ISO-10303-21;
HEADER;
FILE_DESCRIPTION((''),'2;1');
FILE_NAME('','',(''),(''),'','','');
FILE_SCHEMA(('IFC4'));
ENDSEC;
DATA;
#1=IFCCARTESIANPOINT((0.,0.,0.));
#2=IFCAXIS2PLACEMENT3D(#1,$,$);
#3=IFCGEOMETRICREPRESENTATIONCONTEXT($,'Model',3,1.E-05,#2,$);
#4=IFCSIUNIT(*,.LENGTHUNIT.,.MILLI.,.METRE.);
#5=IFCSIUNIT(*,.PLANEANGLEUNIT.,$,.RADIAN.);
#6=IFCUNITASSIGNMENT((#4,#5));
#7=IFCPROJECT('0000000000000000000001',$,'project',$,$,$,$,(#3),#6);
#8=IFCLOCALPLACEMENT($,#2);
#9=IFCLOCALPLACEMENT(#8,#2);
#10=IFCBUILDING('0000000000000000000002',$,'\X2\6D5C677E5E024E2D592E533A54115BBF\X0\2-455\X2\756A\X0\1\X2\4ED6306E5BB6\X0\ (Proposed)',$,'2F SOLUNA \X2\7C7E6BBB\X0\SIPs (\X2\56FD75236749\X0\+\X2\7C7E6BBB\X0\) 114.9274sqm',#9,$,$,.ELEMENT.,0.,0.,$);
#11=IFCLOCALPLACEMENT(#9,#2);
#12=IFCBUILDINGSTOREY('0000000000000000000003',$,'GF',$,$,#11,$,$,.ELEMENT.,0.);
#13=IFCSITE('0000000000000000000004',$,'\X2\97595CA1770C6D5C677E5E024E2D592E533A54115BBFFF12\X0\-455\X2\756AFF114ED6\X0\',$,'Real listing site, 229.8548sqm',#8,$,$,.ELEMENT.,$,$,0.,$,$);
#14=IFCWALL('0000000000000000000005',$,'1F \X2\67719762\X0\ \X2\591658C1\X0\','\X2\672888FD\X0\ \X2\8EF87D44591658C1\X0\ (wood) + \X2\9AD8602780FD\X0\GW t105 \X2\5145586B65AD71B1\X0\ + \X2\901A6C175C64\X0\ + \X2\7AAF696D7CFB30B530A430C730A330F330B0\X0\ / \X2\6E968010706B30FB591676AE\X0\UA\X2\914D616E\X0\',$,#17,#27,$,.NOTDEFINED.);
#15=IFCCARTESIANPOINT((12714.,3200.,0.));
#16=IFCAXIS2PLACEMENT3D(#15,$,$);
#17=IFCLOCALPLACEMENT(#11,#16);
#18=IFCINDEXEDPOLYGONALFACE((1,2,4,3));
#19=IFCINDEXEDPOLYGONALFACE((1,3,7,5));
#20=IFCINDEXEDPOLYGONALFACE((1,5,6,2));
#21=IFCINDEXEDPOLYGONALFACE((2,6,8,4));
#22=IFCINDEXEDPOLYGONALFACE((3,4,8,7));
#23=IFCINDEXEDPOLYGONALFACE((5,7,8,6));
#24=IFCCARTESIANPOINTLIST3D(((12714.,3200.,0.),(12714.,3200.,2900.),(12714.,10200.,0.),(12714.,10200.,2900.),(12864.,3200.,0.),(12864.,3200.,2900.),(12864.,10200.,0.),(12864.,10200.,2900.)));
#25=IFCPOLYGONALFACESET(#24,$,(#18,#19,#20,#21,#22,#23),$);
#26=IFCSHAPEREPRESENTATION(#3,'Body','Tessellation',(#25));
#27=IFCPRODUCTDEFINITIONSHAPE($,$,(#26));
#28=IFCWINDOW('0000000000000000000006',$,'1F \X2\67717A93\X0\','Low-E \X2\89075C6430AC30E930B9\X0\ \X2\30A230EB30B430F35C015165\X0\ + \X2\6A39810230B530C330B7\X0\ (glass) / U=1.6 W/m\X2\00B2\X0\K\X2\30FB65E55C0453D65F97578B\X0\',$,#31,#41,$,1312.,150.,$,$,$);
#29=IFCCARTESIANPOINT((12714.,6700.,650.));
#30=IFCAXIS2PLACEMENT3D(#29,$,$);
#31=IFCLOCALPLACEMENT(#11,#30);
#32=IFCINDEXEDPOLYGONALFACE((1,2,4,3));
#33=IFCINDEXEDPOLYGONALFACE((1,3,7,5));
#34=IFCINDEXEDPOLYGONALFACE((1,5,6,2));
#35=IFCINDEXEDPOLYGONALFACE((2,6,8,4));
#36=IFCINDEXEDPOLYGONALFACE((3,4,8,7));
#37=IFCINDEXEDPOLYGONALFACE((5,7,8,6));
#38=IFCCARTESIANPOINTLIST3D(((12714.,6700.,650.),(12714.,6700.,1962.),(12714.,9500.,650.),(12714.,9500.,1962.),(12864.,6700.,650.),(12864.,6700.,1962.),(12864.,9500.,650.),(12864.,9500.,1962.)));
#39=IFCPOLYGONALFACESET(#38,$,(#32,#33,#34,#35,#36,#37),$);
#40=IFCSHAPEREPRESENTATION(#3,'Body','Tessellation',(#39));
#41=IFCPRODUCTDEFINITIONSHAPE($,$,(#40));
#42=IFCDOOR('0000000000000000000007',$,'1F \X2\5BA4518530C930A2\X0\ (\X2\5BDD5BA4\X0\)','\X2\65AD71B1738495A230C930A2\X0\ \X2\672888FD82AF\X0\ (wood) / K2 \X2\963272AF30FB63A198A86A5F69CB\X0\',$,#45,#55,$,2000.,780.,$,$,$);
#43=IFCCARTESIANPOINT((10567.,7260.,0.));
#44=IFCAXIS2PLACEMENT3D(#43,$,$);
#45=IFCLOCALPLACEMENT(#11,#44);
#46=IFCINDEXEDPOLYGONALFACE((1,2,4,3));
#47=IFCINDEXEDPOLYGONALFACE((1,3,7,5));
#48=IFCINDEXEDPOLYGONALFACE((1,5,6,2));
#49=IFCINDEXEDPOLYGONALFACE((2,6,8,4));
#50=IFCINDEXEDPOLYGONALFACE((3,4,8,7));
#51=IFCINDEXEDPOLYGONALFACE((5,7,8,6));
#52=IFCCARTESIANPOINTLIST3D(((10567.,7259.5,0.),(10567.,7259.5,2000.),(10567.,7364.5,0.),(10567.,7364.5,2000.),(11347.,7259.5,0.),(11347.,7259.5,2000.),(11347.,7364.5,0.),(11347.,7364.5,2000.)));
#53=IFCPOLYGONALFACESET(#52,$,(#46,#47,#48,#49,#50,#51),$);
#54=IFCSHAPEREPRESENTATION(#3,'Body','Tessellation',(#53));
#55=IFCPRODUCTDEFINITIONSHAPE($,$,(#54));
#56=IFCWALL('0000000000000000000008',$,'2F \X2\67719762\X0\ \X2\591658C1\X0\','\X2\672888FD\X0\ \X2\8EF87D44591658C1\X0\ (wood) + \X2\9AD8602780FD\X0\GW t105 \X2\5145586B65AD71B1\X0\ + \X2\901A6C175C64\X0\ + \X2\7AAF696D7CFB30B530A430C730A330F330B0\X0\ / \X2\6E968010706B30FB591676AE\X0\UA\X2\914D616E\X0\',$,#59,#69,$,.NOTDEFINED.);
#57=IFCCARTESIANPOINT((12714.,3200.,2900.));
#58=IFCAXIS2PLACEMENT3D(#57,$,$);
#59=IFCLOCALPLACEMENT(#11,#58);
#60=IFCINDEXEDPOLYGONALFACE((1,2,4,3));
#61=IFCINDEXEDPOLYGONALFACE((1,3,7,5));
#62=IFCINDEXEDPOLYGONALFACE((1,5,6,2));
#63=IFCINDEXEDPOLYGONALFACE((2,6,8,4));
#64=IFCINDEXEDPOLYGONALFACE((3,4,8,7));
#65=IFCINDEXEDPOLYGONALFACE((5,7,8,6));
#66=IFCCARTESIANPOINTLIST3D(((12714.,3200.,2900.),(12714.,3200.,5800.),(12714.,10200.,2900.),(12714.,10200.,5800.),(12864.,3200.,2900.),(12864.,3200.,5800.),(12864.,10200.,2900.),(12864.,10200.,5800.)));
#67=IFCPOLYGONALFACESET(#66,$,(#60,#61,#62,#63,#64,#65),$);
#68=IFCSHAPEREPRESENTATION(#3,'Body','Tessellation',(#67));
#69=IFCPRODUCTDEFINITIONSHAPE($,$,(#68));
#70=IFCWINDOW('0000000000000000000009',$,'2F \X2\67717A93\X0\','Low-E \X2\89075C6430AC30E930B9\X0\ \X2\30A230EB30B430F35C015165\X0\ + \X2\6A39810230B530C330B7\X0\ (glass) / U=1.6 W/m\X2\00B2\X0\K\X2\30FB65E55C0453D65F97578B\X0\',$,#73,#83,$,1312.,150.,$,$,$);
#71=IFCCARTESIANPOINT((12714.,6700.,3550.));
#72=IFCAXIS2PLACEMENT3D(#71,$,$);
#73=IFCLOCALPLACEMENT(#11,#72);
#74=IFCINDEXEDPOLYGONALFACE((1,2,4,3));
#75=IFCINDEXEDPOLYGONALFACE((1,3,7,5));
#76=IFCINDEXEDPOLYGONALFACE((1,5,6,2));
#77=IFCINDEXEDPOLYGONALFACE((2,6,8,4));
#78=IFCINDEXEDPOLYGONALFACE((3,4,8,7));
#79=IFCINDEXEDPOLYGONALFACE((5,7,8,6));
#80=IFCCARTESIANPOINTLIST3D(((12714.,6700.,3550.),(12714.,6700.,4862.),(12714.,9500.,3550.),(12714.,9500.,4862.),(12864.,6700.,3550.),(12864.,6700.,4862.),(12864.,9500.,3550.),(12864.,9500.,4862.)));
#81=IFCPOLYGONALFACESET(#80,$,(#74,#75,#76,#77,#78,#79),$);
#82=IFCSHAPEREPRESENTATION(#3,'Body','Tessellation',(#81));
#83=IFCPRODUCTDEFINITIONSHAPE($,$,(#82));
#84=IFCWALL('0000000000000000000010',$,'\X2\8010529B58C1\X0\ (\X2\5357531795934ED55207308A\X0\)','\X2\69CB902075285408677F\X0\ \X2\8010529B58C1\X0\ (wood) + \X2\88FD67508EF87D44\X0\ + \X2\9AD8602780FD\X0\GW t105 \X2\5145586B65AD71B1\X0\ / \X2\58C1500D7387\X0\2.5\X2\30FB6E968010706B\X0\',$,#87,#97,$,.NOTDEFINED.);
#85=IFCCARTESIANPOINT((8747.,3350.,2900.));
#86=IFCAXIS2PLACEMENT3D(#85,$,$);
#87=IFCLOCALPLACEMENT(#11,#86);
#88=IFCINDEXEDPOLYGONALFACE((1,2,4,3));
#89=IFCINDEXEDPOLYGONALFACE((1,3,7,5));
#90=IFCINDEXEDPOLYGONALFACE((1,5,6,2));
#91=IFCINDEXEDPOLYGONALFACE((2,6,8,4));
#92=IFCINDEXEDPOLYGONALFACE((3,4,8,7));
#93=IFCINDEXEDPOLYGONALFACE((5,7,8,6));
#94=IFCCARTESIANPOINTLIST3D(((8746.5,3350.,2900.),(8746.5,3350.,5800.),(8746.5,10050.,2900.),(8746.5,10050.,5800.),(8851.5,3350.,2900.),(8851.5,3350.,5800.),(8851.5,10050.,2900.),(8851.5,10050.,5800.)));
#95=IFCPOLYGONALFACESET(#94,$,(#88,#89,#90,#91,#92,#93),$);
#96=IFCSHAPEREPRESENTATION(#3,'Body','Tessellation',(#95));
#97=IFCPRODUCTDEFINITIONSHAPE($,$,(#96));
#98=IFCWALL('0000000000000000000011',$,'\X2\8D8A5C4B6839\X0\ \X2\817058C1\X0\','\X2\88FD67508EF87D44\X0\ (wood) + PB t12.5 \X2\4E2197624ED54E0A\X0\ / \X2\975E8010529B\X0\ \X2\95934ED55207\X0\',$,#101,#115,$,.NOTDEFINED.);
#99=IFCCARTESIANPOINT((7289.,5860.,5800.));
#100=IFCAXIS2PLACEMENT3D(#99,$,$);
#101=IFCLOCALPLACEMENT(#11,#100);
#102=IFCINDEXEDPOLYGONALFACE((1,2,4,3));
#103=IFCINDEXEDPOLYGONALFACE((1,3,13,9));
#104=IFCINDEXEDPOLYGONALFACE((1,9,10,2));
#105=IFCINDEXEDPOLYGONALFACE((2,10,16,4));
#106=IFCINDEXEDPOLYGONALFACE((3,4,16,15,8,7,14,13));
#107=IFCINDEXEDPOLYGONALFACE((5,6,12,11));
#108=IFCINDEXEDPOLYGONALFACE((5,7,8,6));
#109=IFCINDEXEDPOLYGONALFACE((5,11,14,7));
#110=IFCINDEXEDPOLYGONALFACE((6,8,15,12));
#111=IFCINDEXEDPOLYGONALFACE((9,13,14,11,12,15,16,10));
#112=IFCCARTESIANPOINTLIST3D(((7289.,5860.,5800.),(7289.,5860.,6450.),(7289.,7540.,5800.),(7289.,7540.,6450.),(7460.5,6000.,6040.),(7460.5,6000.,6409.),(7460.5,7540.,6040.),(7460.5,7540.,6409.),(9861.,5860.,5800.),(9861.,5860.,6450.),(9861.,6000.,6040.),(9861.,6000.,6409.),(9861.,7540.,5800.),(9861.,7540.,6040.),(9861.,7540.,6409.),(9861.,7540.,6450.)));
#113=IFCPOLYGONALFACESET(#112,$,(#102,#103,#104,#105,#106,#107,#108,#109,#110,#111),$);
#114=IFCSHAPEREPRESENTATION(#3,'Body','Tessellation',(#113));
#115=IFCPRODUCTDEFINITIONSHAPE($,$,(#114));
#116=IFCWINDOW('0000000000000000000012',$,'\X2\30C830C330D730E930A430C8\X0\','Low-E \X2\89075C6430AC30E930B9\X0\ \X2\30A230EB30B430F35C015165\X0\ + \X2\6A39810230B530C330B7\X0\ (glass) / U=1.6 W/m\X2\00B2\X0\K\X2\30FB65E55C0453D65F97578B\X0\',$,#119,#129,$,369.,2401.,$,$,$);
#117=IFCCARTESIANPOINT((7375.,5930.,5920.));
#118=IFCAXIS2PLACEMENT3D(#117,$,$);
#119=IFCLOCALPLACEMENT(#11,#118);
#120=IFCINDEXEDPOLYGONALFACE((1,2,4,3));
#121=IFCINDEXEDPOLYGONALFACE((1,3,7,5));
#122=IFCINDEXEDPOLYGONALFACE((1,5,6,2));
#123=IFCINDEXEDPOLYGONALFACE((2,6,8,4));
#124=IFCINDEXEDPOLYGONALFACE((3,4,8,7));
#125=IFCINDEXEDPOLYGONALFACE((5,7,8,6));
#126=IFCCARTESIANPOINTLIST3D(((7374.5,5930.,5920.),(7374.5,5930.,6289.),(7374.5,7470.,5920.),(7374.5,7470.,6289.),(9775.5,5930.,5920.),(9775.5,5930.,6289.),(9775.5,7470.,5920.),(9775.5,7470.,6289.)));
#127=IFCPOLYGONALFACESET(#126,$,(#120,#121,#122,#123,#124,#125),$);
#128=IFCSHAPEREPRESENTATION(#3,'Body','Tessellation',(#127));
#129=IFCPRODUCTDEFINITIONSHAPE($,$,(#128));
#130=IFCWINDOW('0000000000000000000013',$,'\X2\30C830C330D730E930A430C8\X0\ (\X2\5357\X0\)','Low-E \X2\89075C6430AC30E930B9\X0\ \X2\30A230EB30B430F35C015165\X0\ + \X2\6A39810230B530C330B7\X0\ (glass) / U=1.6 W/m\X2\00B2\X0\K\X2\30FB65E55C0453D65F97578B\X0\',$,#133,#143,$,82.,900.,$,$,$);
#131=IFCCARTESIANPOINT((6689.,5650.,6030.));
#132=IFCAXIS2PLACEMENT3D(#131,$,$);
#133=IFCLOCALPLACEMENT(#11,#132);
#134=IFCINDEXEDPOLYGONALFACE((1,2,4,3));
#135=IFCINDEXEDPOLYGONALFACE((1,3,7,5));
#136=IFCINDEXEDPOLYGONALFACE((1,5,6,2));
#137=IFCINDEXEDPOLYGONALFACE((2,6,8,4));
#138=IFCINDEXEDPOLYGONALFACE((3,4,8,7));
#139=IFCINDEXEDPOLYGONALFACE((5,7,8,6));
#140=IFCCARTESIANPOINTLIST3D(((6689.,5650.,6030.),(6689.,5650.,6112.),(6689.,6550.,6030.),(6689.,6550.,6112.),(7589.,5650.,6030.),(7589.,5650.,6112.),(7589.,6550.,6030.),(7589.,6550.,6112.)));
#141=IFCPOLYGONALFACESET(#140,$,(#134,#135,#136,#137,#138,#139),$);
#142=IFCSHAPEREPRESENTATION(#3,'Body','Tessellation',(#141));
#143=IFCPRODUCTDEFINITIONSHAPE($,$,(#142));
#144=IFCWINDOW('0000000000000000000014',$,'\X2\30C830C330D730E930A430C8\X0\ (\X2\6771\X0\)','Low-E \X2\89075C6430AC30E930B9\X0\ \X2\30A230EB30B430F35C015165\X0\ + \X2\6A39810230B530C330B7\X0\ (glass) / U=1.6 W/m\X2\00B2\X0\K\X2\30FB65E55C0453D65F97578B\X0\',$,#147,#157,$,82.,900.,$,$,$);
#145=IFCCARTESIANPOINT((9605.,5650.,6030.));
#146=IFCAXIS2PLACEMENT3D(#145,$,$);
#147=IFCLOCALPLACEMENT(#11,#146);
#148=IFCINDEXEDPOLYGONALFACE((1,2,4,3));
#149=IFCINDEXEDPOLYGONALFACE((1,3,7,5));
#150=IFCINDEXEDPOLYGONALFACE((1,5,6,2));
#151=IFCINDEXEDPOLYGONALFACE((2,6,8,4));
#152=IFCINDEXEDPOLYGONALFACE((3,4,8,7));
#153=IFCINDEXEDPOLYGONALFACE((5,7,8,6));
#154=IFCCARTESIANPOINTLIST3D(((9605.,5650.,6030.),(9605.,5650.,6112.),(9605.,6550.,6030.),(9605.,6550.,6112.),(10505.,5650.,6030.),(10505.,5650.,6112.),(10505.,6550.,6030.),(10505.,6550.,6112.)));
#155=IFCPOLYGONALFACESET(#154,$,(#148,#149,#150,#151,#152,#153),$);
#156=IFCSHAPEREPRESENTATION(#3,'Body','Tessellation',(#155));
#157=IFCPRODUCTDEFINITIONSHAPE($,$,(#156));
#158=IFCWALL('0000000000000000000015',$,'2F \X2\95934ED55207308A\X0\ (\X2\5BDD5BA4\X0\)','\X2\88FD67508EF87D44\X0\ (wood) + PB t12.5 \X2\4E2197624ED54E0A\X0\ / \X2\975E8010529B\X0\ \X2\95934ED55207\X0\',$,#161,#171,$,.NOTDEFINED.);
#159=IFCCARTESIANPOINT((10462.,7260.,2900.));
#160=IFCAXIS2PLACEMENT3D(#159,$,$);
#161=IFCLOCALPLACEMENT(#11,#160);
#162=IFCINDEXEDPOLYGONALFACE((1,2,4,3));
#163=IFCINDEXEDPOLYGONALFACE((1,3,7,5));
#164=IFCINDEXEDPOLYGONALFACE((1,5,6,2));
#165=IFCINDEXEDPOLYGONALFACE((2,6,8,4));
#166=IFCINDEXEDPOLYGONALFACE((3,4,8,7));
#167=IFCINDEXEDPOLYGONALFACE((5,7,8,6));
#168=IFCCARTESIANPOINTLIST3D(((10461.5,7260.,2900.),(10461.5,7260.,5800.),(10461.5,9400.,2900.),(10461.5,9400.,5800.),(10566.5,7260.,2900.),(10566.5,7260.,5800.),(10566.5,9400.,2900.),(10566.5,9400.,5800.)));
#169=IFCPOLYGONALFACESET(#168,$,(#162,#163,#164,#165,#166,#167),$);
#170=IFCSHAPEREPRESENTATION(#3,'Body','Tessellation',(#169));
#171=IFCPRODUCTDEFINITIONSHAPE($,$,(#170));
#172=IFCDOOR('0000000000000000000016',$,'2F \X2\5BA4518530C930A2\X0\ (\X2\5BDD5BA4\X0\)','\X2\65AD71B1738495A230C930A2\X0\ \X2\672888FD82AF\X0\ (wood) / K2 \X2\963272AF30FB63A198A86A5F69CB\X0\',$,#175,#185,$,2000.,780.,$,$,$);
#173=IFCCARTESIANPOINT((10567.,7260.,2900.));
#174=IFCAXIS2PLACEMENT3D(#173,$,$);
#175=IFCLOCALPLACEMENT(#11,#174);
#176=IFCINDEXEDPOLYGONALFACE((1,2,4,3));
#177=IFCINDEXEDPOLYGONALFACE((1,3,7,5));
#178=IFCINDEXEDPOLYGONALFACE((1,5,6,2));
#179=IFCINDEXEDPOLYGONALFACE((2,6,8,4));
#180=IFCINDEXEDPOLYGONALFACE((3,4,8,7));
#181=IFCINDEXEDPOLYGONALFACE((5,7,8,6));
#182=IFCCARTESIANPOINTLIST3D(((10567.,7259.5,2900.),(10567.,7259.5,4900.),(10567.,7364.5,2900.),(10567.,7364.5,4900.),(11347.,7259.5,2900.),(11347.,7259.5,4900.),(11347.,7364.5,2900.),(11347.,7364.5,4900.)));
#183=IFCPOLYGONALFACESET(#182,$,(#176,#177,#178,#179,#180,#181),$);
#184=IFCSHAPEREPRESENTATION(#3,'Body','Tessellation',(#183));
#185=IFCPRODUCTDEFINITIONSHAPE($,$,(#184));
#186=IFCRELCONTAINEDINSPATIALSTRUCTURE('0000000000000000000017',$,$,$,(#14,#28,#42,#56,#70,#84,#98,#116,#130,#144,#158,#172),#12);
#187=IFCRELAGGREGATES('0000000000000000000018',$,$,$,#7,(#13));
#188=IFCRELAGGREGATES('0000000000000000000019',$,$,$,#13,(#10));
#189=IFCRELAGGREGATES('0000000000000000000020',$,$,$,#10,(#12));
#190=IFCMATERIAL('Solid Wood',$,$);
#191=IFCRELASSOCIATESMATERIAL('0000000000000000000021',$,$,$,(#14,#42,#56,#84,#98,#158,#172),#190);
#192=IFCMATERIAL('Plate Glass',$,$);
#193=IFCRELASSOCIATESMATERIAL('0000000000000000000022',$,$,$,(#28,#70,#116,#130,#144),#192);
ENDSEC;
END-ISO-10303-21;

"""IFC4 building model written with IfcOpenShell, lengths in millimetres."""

from ifc_helpers import new_model, si_unit, frame, frame_2d, origin, place, context, project, spatial, rectangle, extrude, material, element, fill, save


model = new_model("IFC4")

# Units and contexts
model_context = context("Model", 3, precision=1e-05, world=origin())
ifc_project = project(units=[si_unit("LENGTHUNIT", "METRE", prefix="MILLI"), si_unit("PLANEANGLEUNIT", "RADIAN")], contexts=[model_context])

# Site, building, storey
site_placement = place(None, origin())
site = spatial("IfcSite", under=ifc_project, at=site_placement, Name="静岡県浜松市中央区向宿２-455番１他", ObjectType="Real listing site, 229.8548sqm", CompositionType="ELEMENT", RefElevation=0.0)
building_placement = place(site_placement, origin())
building = spatial("IfcBuilding", under=site, at=building_placement, Name="浜松市中央区向宿2-455番1他の家 (Proposed)", ObjectType="2F SOLUNA 籾殻SIPs (国産杉+籾殻) 114.9274sqm", CompositionType="ELEMENT", ElevationOfRefHeight=0.0, ElevationOfTerrain=0.0)
storey_placement = place(building_placement, origin())
storey = spatial("IfcBuildingStorey", under=building, at=storey_placement, Name="GF", CompositionType="ELEMENT", Elevation=0.0)

# Wall, opening, window
ifc_material_1 = material(Name="Solid Wood")
wall_1_placement = place(storey_placement, frame((12714.0, 3200.0, 0.0)))
wall_1 = element("IfcWall", 1, at=wall_1_placement, inside=storey, material=ifc_material_1, Name="1F 東面 外壁", Description="木製 軸組外壁 (wood) + 高性能GW t105 充填断熱 + 通気層 + 窯業系サイディング / 準耐火・外皮UA配慮", PredefinedType="NOTDEFINED", context=model_context, shape_type="SweptSolid", body=[
    extrude(rectangle(XDim=150.0, YDim=7000.0, at=frame_2d((75.0, 3500.0))), frame((12714.0, 3200.0, 0.0)), (0.0, 0.0, 1.0), 2900.0),
])
opening_1_placement = place(storey_placement, frame((12714.0, 6700.0, 650.0)))
opening_1 = element("IfcOpeningElement", 2, at=opening_1_placement, cuts=wall_1, PredefinedType="NOTDEFINED", context=model_context, shape_type="SweptSolid", body=[
    extrude(rectangle(XDim=150.0, YDim=2800.0, at=frame_2d((75.0, 1400.0))), frame((12714.0, 6700.0, 650.0)), (0.0, 0.0, 1.0), 1312.0),
])
ifc_material_2 = material(Name="Plate Glass")
window_1_placement = place(storey_placement, frame((12714.0, 6700.0, 650.0)))
window_1 = element("IfcWindow", 3, at=window_1_placement, inside=storey, material=ifc_material_2, Name="1F 東窓", Description="Low-E 複層ガラス アルゴン封入 + 樹脂サッシ (glass) / U=1.6 W/m²K・日射取得型", OverallHeight=1312.0, OverallWidth=150.0, context=model_context, shape_type="SweptSolid", body=[
    extrude(rectangle(XDim=150.0, YDim=2800.0, at=frame_2d((75.0, 1400.0))), frame((12714.0, 6700.0, 650.0)), (0.0, 0.0, 1.0), 1312.0),
])
fill(opening_1, window_1)

# Door
door_1_placement = place(storey_placement, frame((10567.0, 7260.0, 0.0)))
element("IfcDoor", 4, at=door_1_placement, inside=storey, material=ifc_material_1, Name="1F 室内ドア (寝室)", Description="断熱玄関ドア 木製芯 (wood) / K2 防犯・採風機構", OverallHeight=2000.0, OverallWidth=780.0, context=model_context, shape_type="SweptSolid", body=[
    extrude(rectangle(XDim=780.0, YDim=105.0, at=frame_2d((390.0, 52.0))), frame((10567.0, 7260.0, 0.0)), (0.0, 0.0, 1.0), 2000.0),
])

# Wall, opening, window
wall_2_placement = place(storey_placement, frame((12714.0, 3200.0, 2900.0)))
wall_2 = element("IfcWall", 5, at=wall_2_placement, inside=storey, material=ifc_material_1, Name="2F 東面 外壁", Description="木製 軸組外壁 (wood) + 高性能GW t105 充填断熱 + 通気層 + 窯業系サイディング / 準耐火・外皮UA配慮", PredefinedType="NOTDEFINED", context=model_context, shape_type="SweptSolid", body=[
    extrude(rectangle(XDim=150.0, YDim=7000.0, at=frame_2d((75.0, 3500.0))), frame((12714.0, 3200.0, 2900.0)), (0.0, 0.0, 1.0), 2900.0),
])
opening_2_placement = place(storey_placement, frame((12714.0, 6700.0, 3550.0)))
opening_2 = element("IfcOpeningElement", 6, at=opening_2_placement, cuts=wall_2, PredefinedType="NOTDEFINED", context=model_context, shape_type="SweptSolid", body=[
    extrude(rectangle(XDim=150.0, YDim=2800.0, at=frame_2d((75.0, 1400.0))), frame((12714.0, 6700.0, 3550.0)), (0.0, 0.0, 1.0), 1312.0),
])
window_2_placement = place(storey_placement, frame((12714.0, 6700.0, 3550.0)))
window_2 = element("IfcWindow", 7, at=window_2_placement, inside=storey, material=ifc_material_2, Name="2F 東窓", Description="Low-E 複層ガラス アルゴン封入 + 樹脂サッシ (glass) / U=1.6 W/m²K・日射取得型", OverallHeight=1312.0, OverallWidth=150.0, context=model_context, shape_type="SweptSolid", body=[
    extrude(rectangle(XDim=150.0, YDim=2800.0, at=frame_2d((75.0, 1400.0))), frame((12714.0, 6700.0, 3550.0)), (0.0, 0.0, 1.0), 1312.0),
])
fill(opening_2, window_2)

# Wall
wall_3_placement = place(storey_placement, frame((8747.0, 3350.0, 2900.0)))
element("IfcWall", 8, at=wall_3_placement, inside=storey, material=ifc_material_1, Name="耐力壁 (南北間仕切り)", Description="構造用合板 耐力壁 (wood) + 製材軸組 + 高性能GW t105 充填断熱 / 壁倍率2.5・準耐火", PredefinedType="NOTDEFINED", context=model_context, shape_type="SweptSolid", body=[
    extrude(rectangle(XDim=105.0, YDim=6700.0, at=frame_2d((52.0, 3350.0))), frame((8747.0, 3350.0, 2900.0)), (0.0, 0.0, 1.0), 2900.0),
])

# Wall, openings, windows
wall_4_placement = place(storey_placement, frame((7289.0, 5860.0, 5800.0)))
wall_4 = element("IfcWall", 9, at=wall_4_placement, inside=storey, material=ifc_material_1, Name="越屋根 腰壁", Description="製材軸組 (wood) + PB t12.5 両面仕上 / 非耐力 間仕切", PredefinedType="NOTDEFINED", context=model_context, shape_type="SweptSolid", body=[
    extrude(rectangle(XDim=2572.0, YDim=1680.0, at=frame_2d((1286.0, 840.0))), frame((7289.0, 5860.0, 5800.0)), (0.0, 0.0, 1.0), 650.0),
])
opening_3_placement = place(storey_placement, frame((7375.0, 5930.0, 5920.0)))
opening_3 = element("IfcOpeningElement", 10, at=opening_3_placement, cuts=wall_4, PredefinedType="NOTDEFINED", context=model_context, shape_type="SweptSolid", body=[
    extrude(rectangle(XDim=2401.0, YDim=1540.0, at=frame_2d((1200.0, 770.0))), frame((7375.0, 5930.0, 5920.0)), (0.0, 0.0, 1.0), 369.0),
])
opening_4_placement = place(storey_placement, frame((6689.0, 5650.0, 6030.0)))
opening_4 = element("IfcOpeningElement", 11, at=opening_4_placement, cuts=wall_4, PredefinedType="NOTDEFINED", context=model_context, shape_type="SweptSolid", body=[
    extrude(rectangle(XDim=900.0, YDim=900.0, at=frame_2d((450.0, 450.0))), frame((6689.0, 5650.0, 6030.0)), (0.0, 0.0, 1.0), 82.0),
])
opening_5_placement = place(storey_placement, frame((9605.0, 5650.0, 6030.0)))
opening_5 = element("IfcOpeningElement", 12, at=opening_5_placement, cuts=wall_4, PredefinedType="NOTDEFINED", context=model_context, shape_type="SweptSolid", body=[
    extrude(rectangle(XDim=900.0, YDim=900.0, at=frame_2d((450.0, 450.0))), frame((9605.0, 5650.0, 6030.0)), (0.0, 0.0, 1.0), 82.0),
])
window_3_placement = place(storey_placement, frame((7375.0, 5930.0, 5920.0)))
window_3 = element("IfcWindow", 13, at=window_3_placement, inside=storey, material=ifc_material_2, Name="トップライト", Description="Low-E 複層ガラス アルゴン封入 + 樹脂サッシ (glass) / U=1.6 W/m²K・日射取得型", OverallHeight=369.0, OverallWidth=2401.0, context=model_context, shape_type="SweptSolid", body=[
    extrude(rectangle(XDim=2401.0, YDim=1540.0, at=frame_2d((1200.0, 770.0))), frame((7375.0, 5930.0, 5920.0)), (0.0, 0.0, 1.0), 369.0),
])
fill(opening_3, window_3)
window_4_placement = place(storey_placement, frame((6689.0, 5650.0, 6030.0)))
window_4 = element("IfcWindow", 14, at=window_4_placement, inside=storey, material=ifc_material_2, Name="トップライト (南)", Description="Low-E 複層ガラス アルゴン封入 + 樹脂サッシ (glass) / U=1.6 W/m²K・日射取得型", OverallHeight=82.0, OverallWidth=900.0, context=model_context, shape_type="SweptSolid", body=[
    extrude(rectangle(XDim=900.0, YDim=900.0, at=frame_2d((450.0, 450.0))), frame((6689.0, 5650.0, 6030.0)), (0.0, 0.0, 1.0), 82.0),
])
fill(opening_4, window_4)
window_5_placement = place(storey_placement, frame((9605.0, 5650.0, 6030.0)))
window_5 = element("IfcWindow", 15, at=window_5_placement, inside=storey, material=ifc_material_2, Name="トップライト (東)", Description="Low-E 複層ガラス アルゴン封入 + 樹脂サッシ (glass) / U=1.6 W/m²K・日射取得型", OverallHeight=82.0, OverallWidth=900.0, context=model_context, shape_type="SweptSolid", body=[
    extrude(rectangle(XDim=900.0, YDim=900.0, at=frame_2d((450.0, 450.0))), frame((9605.0, 5650.0, 6030.0)), (0.0, 0.0, 1.0), 82.0),
])
fill(opening_5, window_5)

# Wall
wall_5_placement = place(storey_placement, frame((10462.0, 7260.0, 2900.0)))
element("IfcWall", 16, at=wall_5_placement, inside=storey, material=ifc_material_1, Name="2F 間仕切り (寝室)", Description="製材軸組 (wood) + PB t12.5 両面仕上 / 非耐力 間仕切", PredefinedType="NOTDEFINED", context=model_context, shape_type="SweptSolid", body=[
    extrude(rectangle(XDim=105.0, YDim=2140.0, at=frame_2d((52.0, 1070.0))), frame((10462.0, 7260.0, 2900.0)), (0.0, 0.0, 1.0), 2900.0),
])

# Door
door_2_placement = place(storey_placement, frame((10567.0, 7260.0, 2900.0)))
element("IfcDoor", 17, at=door_2_placement, inside=storey, material=ifc_material_1, Name="2F 室内ドア (寝室)", Description="断熱玄関ドア 木製芯 (wood) / K2 防犯・採風機構", OverallHeight=2000.0, OverallWidth=780.0, context=model_context, shape_type="SweptSolid", body=[
    extrude(rectangle(XDim=780.0, YDim=105.0, at=frame_2d((390.0, 52.0))), frame((10567.0, 7260.0, 2900.0)), (0.0, 0.0, 1.0), 2000.0),
])

save(model, "model.ifc")
